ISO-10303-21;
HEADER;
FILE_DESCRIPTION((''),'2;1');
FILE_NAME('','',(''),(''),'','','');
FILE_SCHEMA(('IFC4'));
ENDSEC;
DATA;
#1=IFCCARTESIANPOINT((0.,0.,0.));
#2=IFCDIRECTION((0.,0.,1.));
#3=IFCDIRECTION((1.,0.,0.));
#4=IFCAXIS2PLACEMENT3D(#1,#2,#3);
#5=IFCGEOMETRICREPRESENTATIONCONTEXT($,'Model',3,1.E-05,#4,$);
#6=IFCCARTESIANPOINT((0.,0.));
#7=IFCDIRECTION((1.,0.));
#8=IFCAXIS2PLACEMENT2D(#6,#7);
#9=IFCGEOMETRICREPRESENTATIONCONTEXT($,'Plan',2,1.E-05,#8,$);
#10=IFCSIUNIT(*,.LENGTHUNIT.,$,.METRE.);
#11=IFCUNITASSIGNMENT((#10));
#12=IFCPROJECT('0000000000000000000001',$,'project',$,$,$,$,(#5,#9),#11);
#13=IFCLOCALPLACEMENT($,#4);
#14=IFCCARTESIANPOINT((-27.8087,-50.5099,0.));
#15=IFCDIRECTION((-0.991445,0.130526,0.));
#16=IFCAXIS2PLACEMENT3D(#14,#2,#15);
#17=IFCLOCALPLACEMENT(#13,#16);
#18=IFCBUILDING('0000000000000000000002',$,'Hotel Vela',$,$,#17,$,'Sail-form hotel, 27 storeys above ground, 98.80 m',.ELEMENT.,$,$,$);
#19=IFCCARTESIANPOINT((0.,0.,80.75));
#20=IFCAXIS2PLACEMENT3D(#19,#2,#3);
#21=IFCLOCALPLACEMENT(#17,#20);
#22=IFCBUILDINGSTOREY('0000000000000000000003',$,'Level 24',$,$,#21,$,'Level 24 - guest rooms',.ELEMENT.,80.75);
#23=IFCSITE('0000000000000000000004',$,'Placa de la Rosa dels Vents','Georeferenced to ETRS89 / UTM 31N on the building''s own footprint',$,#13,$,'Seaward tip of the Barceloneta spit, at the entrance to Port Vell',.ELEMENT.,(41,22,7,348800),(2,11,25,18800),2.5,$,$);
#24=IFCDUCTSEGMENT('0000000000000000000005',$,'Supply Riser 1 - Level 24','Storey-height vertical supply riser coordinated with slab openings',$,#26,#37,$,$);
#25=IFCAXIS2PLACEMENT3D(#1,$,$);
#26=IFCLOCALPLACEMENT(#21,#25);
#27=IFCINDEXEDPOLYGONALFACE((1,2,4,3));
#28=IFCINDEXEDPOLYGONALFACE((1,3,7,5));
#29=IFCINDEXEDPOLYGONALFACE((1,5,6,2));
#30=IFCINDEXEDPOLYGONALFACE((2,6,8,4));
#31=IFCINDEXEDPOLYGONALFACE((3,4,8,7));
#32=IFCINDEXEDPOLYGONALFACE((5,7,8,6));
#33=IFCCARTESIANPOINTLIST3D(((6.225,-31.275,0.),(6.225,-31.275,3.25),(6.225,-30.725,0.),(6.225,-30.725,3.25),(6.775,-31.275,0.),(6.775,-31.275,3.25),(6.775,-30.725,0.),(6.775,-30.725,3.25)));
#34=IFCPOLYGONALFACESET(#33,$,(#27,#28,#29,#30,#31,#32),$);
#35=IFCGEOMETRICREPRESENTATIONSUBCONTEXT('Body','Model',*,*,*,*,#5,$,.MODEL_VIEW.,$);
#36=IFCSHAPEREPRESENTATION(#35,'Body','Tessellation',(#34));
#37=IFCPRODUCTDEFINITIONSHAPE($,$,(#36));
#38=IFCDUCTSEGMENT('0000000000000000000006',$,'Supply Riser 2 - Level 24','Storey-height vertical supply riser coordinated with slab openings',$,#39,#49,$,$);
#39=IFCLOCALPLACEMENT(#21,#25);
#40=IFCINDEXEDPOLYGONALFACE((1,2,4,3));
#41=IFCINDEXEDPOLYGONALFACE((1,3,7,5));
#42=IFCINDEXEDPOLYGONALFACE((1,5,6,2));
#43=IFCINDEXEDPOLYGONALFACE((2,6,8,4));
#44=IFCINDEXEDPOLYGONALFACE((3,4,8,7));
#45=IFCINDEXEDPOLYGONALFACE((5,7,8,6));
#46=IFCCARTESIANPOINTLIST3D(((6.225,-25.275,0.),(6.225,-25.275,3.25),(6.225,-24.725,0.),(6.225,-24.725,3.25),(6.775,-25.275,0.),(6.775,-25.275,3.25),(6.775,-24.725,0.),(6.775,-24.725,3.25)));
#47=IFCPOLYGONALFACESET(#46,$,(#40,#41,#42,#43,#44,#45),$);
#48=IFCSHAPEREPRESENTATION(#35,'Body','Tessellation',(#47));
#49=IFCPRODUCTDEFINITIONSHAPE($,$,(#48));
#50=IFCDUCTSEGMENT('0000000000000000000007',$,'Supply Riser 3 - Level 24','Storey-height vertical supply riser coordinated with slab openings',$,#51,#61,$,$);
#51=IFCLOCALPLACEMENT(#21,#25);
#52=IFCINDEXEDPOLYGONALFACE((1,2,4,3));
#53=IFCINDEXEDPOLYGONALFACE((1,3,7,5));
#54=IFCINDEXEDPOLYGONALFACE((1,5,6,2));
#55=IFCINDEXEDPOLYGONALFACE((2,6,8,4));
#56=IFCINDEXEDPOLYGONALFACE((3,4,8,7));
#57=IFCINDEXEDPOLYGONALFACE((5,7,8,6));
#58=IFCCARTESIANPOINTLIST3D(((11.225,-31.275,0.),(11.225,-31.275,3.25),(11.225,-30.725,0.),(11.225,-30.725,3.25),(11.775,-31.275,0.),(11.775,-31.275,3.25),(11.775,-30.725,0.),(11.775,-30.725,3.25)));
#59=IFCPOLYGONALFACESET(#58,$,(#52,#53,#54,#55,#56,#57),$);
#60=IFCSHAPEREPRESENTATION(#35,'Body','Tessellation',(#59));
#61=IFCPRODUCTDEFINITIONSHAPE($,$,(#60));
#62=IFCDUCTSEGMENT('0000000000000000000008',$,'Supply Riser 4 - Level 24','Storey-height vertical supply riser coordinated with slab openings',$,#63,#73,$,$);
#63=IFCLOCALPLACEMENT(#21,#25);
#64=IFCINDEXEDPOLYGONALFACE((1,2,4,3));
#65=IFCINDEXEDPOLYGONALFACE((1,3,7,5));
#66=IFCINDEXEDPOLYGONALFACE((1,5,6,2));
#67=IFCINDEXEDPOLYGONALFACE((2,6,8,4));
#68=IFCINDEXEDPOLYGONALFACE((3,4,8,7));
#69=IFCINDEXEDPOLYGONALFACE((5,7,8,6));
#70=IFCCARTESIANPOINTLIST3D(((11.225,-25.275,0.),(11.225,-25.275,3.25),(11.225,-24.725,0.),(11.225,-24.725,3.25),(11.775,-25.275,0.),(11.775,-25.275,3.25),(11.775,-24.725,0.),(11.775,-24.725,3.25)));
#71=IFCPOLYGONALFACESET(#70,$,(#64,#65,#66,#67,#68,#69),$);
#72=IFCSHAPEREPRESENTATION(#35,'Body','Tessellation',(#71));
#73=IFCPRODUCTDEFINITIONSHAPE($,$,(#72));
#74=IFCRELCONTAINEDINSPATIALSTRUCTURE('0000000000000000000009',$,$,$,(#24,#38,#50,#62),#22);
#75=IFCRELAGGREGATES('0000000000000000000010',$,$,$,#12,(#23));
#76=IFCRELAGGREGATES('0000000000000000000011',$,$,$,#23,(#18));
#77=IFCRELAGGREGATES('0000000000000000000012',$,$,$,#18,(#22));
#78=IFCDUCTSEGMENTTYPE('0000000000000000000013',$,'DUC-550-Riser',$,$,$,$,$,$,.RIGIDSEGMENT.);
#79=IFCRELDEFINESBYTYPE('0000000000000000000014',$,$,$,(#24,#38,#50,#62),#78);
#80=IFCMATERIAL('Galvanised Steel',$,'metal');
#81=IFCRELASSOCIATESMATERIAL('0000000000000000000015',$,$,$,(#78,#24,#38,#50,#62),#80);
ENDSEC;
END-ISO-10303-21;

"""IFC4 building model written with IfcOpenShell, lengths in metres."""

from ifc_helpers import new_model, si_unit, frame, origin_with_axes, origin_2d_with_axis, place, context, subcontext, project, spatial, line, indexed_curve, outline, extrude, material, type_object, element, save


model = new_model("IFC4")

# Units and contexts
model_context = context("Model", 3, precision=1e-05, world=origin_with_axes())
plan_context = context("Plan", 2, precision=1e-05, world=origin_2d_with_axis())
body_context = subcontext(model_context, "Body", "Model", "MODEL_VIEW")
ifc_project = project(units=[si_unit("LENGTHUNIT", "METRE")], contexts=[model_context, plan_context])

# Site, building, storey
site_placement = place(None, origin_with_axes())
site = spatial("IfcSite", under=ifc_project, at=site_placement, Name="Placa de la Rosa dels Vents", Description="Georeferenced to ETRS89 / UTM 31N on the building's own footprint", LongName="Seaward tip of the Barceloneta spit, at the entrance to Port Vell", CompositionType="ELEMENT", RefLatitude=(41, 22, 7, 348800), RefLongitude=(2, 11, 25, 18800), RefElevation=2.5)
building_placement = place(site_placement, frame((-27.8087, -50.5099, 0.0), z_axis=(0.0, 0.0, 1.0), x_axis=(-0.991445, 0.130526, 0.0)))
building = spatial("IfcBuilding", under=site, at=building_placement, Name="Hotel Vela", LongName="Sail-form hotel, 27 storeys above ground, 98.80 m", CompositionType="ELEMENT")
storey_placement = place(building_placement, frame((0.0, 0.0, 80.75), z_axis=(0.0, 0.0, 1.0), x_axis=(1.0, 0.0, 0.0)))
storey = spatial("IfcBuildingStorey", under=building, at=storey_placement, Name="Level 24", LongName="Level 24 - guest rooms", CompositionType="ELEMENT", Elevation=80.75)

# Duct segments
ifc_material = material(Name="Galvanised Steel", Category="metal")
duct_segment_type = type_object("IfcDuctSegmentType", Name="DUC-550-Riser", PredefinedType="RIGIDSEGMENT", material=ifc_material)
for number, where, z_axis, x_axis, name in (
    (1, (6.225, -31.275, 0.0), (0.0, 0.0, 1.0), (1.0, 0.0, 0.0), "Supply Riser 1 - Level 24"),
    (2, (6.225, -25.275, 0.0), (0.0, 0.0, 1.0), (1.0, 0.0, 0.0), "Supply Riser 2 - Level 24"),
    (3, (11.225, -31.275, 0.0), (0.0, 0.0, 1.0), (1.0, 0.0, 0.0), "Supply Riser 3 - Level 24"),
    (4, (11.225, -25.275, 0.0), (0.0, 0.0, 1.0), (1.0, 0.0, 0.0), "Supply Riser 4 - Level 24"),
):
    element("IfcDuctSegment", number, at=place(storey_placement, frame(where, z_axis=z_axis, x_axis=x_axis)), inside=storey, type_object=duct_segment_type, material=ifc_material, Name=name, Description="Storey-height vertical supply riser coordinated with slab openings", context=body_context, shape_type="SweptSolid", body=[
        extrude(outline(indexed_curve([(0.0, 0.0), (0.55, 0.0), (0.55, 0.55), (0.0, 0.55)], segments=[line(1, 2, 3, 4, 1)])), origin_with_axes(), (0.0, 0.0, 1.0), 3.25),
    ])

save(model, "model.ifc")
